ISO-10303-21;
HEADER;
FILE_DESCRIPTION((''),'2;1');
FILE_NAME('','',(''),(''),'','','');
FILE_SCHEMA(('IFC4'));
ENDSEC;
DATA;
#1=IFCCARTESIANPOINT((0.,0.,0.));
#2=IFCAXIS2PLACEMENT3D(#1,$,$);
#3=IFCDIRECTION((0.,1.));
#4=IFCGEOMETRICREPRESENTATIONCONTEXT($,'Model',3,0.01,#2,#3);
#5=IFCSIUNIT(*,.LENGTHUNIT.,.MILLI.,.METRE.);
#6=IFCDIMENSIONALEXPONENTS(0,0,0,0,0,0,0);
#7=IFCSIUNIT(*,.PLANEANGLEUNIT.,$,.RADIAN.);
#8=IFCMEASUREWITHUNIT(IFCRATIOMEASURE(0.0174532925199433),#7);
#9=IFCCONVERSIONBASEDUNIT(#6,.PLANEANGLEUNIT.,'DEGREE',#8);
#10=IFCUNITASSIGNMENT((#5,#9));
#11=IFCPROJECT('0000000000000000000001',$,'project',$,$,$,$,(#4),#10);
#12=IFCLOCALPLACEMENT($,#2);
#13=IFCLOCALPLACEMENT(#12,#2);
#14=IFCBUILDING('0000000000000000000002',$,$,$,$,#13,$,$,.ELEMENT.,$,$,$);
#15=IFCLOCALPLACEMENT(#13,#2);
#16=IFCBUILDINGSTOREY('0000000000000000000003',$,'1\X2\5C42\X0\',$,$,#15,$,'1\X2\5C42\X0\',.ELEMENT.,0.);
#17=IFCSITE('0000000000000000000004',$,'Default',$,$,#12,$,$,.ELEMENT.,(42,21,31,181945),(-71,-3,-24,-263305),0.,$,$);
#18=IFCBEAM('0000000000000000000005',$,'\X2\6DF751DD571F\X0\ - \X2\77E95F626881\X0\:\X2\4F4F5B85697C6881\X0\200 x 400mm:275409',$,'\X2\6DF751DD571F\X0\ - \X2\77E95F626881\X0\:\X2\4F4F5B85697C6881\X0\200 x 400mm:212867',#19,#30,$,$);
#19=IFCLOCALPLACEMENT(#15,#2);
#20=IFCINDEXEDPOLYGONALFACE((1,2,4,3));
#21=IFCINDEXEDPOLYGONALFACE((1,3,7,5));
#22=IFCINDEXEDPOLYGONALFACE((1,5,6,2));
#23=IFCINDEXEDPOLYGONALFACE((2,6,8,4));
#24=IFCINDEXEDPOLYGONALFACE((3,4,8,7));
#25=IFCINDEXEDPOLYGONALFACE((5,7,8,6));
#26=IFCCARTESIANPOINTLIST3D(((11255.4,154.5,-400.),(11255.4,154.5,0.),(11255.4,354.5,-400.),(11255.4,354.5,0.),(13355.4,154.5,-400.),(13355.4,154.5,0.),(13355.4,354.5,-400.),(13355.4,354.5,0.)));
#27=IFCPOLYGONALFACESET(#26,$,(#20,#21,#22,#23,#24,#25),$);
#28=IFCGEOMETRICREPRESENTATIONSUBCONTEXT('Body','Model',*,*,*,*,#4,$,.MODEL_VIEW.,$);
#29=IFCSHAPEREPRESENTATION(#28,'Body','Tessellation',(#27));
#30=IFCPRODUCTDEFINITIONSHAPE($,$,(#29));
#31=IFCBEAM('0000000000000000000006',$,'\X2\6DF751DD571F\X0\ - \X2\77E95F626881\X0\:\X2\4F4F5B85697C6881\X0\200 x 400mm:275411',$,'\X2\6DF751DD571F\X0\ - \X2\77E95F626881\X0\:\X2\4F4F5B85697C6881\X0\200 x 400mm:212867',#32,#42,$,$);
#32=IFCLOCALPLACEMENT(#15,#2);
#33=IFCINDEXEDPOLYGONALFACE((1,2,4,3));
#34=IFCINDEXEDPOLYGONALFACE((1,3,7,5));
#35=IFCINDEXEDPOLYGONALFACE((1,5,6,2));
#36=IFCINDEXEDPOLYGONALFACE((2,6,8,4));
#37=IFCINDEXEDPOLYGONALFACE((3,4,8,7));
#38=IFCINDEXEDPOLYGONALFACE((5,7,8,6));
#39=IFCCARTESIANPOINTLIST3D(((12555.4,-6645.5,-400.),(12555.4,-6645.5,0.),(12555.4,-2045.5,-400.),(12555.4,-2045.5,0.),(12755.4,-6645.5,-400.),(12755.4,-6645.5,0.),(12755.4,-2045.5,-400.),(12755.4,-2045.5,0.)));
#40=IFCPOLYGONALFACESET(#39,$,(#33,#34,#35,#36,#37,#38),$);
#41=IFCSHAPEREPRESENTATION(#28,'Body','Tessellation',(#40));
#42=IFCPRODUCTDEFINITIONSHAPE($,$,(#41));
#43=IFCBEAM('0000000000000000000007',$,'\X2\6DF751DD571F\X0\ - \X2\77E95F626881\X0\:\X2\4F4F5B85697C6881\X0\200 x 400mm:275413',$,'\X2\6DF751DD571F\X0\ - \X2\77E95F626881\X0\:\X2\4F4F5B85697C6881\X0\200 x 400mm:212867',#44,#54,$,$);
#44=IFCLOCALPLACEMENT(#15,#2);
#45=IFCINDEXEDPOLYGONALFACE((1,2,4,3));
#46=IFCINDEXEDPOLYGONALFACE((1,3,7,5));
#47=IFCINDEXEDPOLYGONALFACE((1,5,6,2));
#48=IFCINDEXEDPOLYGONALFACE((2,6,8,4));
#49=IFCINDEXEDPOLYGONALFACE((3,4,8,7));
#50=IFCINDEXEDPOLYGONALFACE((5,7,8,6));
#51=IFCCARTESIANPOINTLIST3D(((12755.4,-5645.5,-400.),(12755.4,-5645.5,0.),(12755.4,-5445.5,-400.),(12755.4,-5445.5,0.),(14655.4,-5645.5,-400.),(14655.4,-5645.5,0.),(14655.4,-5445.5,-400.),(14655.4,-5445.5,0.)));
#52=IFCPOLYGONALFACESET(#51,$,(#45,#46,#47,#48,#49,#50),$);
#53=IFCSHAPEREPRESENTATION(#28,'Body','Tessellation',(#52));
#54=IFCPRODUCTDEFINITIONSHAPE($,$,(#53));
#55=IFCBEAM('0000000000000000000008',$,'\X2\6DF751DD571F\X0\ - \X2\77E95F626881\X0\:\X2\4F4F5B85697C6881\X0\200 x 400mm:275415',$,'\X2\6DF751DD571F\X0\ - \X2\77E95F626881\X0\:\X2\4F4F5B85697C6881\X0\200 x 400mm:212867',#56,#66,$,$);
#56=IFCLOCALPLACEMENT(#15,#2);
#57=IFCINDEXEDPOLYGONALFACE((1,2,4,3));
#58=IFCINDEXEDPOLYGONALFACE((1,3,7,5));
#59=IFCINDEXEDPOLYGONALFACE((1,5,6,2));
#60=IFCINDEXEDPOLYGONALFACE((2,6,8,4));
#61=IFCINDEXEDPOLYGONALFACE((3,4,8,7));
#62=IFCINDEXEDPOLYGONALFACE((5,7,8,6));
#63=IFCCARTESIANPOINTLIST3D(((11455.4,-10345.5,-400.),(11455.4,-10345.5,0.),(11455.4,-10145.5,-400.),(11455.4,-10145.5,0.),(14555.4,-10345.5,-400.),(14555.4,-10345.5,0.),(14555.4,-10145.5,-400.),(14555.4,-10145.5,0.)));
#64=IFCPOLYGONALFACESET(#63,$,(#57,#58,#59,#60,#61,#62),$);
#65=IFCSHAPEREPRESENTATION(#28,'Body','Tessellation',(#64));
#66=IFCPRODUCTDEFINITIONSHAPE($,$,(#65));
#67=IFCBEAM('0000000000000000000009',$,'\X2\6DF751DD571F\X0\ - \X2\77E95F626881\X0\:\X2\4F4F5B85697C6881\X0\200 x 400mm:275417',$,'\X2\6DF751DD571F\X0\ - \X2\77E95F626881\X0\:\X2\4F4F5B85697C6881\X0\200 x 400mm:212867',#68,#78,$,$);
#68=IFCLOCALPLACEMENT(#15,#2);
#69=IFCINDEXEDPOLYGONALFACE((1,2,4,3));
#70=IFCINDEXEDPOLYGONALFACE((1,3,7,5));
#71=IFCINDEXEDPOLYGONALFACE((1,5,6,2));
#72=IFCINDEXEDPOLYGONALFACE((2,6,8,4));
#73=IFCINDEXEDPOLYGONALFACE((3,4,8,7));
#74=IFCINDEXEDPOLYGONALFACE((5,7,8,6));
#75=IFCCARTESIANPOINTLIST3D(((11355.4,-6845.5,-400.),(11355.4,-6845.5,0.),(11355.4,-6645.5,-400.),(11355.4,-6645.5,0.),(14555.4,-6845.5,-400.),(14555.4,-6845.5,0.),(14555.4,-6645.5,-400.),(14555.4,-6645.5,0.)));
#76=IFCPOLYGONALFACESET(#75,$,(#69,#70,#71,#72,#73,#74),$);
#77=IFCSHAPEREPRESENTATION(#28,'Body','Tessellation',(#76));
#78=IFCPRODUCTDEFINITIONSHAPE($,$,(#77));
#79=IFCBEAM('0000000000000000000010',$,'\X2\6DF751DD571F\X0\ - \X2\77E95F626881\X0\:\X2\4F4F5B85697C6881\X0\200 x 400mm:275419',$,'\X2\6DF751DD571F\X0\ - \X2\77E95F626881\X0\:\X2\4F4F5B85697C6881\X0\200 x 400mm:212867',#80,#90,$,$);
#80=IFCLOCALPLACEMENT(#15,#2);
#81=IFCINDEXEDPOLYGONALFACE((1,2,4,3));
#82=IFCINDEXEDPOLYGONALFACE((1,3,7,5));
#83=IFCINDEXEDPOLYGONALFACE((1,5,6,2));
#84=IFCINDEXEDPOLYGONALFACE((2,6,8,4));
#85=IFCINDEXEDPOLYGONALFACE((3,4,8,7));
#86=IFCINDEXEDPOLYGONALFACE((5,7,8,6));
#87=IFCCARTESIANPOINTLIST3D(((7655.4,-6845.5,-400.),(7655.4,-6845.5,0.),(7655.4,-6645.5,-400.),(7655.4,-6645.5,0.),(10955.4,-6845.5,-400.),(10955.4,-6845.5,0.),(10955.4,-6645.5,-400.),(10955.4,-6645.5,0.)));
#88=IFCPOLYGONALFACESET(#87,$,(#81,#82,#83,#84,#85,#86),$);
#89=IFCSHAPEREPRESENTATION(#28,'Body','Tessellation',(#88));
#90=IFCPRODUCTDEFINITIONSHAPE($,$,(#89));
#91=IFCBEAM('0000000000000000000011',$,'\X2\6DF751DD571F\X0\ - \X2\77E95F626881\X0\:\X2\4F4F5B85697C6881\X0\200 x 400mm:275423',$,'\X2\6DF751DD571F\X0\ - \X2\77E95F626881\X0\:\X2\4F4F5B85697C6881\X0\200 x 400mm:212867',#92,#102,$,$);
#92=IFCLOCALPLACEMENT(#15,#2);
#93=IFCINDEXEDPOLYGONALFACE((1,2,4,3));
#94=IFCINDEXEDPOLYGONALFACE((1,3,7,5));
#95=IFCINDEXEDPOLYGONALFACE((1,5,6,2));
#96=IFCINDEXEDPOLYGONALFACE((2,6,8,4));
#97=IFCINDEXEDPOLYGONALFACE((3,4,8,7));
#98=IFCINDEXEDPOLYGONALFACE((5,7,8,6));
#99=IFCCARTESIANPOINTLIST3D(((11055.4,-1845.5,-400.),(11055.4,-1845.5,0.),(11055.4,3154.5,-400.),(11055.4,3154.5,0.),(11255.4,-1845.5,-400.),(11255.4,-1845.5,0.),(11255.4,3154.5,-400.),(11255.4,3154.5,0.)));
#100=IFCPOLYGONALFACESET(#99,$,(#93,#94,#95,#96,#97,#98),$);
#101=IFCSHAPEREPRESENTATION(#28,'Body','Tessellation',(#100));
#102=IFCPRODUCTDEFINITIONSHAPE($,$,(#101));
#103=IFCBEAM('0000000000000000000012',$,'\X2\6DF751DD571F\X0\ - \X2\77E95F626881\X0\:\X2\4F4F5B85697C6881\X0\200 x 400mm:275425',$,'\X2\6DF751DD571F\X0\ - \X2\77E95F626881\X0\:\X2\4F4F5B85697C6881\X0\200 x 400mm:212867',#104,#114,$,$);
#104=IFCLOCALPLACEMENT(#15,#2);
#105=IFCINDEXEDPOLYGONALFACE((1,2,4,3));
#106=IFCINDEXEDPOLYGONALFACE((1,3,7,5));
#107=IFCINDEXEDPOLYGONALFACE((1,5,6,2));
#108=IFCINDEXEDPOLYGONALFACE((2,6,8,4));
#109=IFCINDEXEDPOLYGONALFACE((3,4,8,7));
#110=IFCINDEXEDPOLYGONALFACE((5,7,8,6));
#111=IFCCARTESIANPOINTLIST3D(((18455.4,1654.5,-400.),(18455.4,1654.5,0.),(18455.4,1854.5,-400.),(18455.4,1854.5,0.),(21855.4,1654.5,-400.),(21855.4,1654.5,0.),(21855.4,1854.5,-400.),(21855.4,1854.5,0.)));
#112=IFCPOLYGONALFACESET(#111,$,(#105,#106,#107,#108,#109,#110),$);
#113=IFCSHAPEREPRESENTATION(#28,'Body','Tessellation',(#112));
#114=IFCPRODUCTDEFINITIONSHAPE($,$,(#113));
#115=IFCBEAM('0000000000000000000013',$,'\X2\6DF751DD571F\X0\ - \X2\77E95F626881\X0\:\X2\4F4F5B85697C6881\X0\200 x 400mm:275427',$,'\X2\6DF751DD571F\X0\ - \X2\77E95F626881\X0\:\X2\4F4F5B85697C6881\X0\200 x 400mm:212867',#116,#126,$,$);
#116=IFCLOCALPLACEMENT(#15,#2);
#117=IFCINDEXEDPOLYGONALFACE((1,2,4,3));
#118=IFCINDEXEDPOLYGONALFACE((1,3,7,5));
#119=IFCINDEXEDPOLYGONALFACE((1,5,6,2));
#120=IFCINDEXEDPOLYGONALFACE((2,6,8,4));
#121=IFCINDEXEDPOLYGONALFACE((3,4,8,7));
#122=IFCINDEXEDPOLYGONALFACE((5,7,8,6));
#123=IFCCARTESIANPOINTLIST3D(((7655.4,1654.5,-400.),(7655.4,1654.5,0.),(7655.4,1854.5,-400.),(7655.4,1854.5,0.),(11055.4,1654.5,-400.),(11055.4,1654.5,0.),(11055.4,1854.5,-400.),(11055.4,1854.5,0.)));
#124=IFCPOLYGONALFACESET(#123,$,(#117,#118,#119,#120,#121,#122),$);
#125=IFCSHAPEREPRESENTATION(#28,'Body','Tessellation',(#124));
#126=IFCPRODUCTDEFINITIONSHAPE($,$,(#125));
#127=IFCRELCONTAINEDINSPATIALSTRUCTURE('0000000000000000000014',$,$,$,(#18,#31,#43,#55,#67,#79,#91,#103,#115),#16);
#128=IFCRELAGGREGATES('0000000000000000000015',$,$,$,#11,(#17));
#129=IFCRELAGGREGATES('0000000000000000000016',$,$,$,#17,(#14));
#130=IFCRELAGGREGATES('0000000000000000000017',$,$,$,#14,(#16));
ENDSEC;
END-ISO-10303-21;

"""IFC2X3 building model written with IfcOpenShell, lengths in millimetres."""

from ifc_helpers import new_model, entity, si_unit, converted_unit, direction, frame, frame_2d, origin, place, context, subcontext, project, spatial, rectangle, extrude, element, save


model = new_model("IFC2X3")

# Units and contexts
model_context = context("Model", 3, precision=0.01, world=origin(), true_north=direction((0.0, 1.0)))
body_context = subcontext(model_context, "Body", "Model", "MODEL_VIEW")
ifc_project = project(units=[si_unit("LENGTHUNIT", "METRE", prefix="MILLI"), converted_unit("PLANEANGLEUNIT", "DEGREE", entity("IfcRatioMeasure", 0.0174532925199433), si_unit("PLANEANGLEUNIT", "RADIAN"), dimensions=[0, 0, 0, 0, 0, 0, 0])], contexts=[model_context])

# Site, building, storey
site_placement = place(None, origin())
site = spatial("IfcSite", under=ifc_project, at=site_placement, Name="Default", CompositionType="ELEMENT", RefLatitude=(42, 21, 31, 181945), RefLongitude=(-71, -3, -24, -263305), RefElevation=0.0)
building_placement = place(site_placement, origin())
building = spatial("IfcBuilding", under=site, at=building_placement, CompositionType="ELEMENT")
storey_placement = place(building_placement, origin())
storey = spatial("IfcBuildingStorey", under=building, at=storey_placement, Name="1层", LongName="1层", CompositionType="ELEMENT", Elevation=0.0)

# Beams
beam_1_placement = place(storey_placement, frame((11155.4, 254.5, 0.0)))
element("IfcBeam", 1, at=beam_1_placement, inside=storey, Name="混凝土 - 矩形梁:住宅楼梁200 x 400mm:275409", ObjectType="混凝土 - 矩形梁:住宅楼梁200 x 400mm:212867", context=body_context, shape_type="SweptSolid", body=[
    extrude(rectangle(XDim=400.0, YDim=200.0, at=frame_2d((0.0, 0.0), x_axis=(1.0, 0.0))), frame((100.0, 0.0, -200.0), z_axis=(1.0, 0.0, 0.0), x_axis=(0.0, 0.0, -1.0)), (0.0, 0.0, 1.0), 2100.0),
])
beam_2_placement = place(storey_placement, frame((12655.4, -1945.5, 0.0), z_axis=(0.0, 0.0, 1.0), x_axis=(0.0, -1.0, 0.0)))
element("IfcBeam", 2, at=beam_2_placement, inside=storey, Name="混凝土 - 矩形梁:住宅楼梁200 x 400mm:275411", ObjectType="混凝土 - 矩形梁:住宅楼梁200 x 400mm:212867", context=body_context, shape_type="SweptSolid", body=[
    extrude(rectangle(XDim=400.0, YDim=200.0, at=frame_2d((0.0, 0.0), x_axis=(1.0, 0.0))), frame((100.0, 0.0, -200.0), z_axis=(1.0, 0.0, 0.0), x_axis=(0.0, 0.0, -1.0)), (0.0, 0.0, 1.0), 4600.0),
])
beam_3_placement = place(storey_placement, frame((12655.4, -5545.5, 0.0)))
element("IfcBeam", 3, at=beam_3_placement, inside=storey, Name="混凝土 - 矩形梁:住宅楼梁200 x 400mm:275413", ObjectType="混凝土 - 矩形梁:住宅楼梁200 x 400mm:212867", context=body_context, shape_type="SweptSolid", body=[
    extrude(rectangle(XDim=400.0, YDim=200.0, at=frame_2d((0.0, 0.0), x_axis=(1.0, 0.0))), frame((100.0, 0.0, -200.0), z_axis=(1.0, 0.0, 0.0), x_axis=(0.0, 0.0, -1.0)), (0.0, 0.0, 1.0), 1900.0),
])
beam_4_placement = place(storey_placement, frame((11455.4, -10245.5, 0.0)))
element("IfcBeam", 4, at=beam_4_placement, inside=storey, Name="混凝土 - 矩形梁:住宅楼梁200 x 400mm:275415", ObjectType="混凝土 - 矩形梁:住宅楼梁200 x 400mm:212867", context=body_context, shape_type="SweptSolid", body=[
    extrude(rectangle(XDim=400.0, YDim=200.0, at=frame_2d((0.0, 0.0), x_axis=(1.0, 0.0))), frame((0.0, 0.0, -200.0), z_axis=(1.0, 0.0, 0.0), x_axis=(0.0, 0.0, -1.0)), (0.0, 0.0, 1.0), 3100.0),
])
beam_5_placement = place(storey_placement, frame((11155.4, -6745.5, 0.0)))
element("IfcBeam", 5, at=beam_5_placement, inside=storey, Name="混凝土 - 矩形梁:住宅楼梁200 x 400mm:275417", ObjectType="混凝土 - 矩形梁:住宅楼梁200 x 400mm:212867", context=body_context, shape_type="SweptSolid", body=[
    extrude(rectangle(XDim=400.0, YDim=200.0, at=frame_2d((0.0, 0.0), x_axis=(1.0, 0.0))), frame((200.0, 0.0, -200.0), z_axis=(1.0, 0.0, 0.0), x_axis=(0.0, 0.0, -1.0)), (0.0, 0.0, 1.0), 3200.0),
])
beam_6_placement = place(storey_placement, frame((11155.4, -6745.5, 0.0), z_axis=(0.0, 0.0, 1.0), x_axis=(-1.0, 0.0, 0.0)))
element("IfcBeam", 6, at=beam_6_placement, inside=storey, Name="混凝土 - 矩形梁:住宅楼梁200 x 400mm:275419", ObjectType="混凝土 - 矩形梁:住宅楼梁200 x 400mm:212867", context=body_context, shape_type="SweptSolid", body=[
    extrude(rectangle(XDim=400.0, YDim=200.0, at=frame_2d((0.0, 0.0), x_axis=(1.0, 0.0))), frame((200.0, 0.0, -200.0), z_axis=(1.0, 0.0, 0.0), x_axis=(0.0, 0.0, -1.0)), (0.0, 0.0, 1.0), 3300.0),
])
beam_7_placement = place(storey_placement, frame((11155.4, 3254.5, 0.0), z_axis=(0.0, 0.0, 1.0), x_axis=(0.0, -1.0, 0.0)))
element("IfcBeam", 7, at=beam_7_placement, inside=storey, Name="混凝土 - 矩形梁:住宅楼梁200 x 400mm:275423", ObjectType="混凝土 - 矩形梁:住宅楼梁200 x 400mm:212867", context=body_context, shape_type="SweptSolid", body=[
    extrude(rectangle(XDim=400.0, YDim=200.0, at=frame_2d((0.0, 0.0), x_axis=(1.0, 0.0))), frame((100.0, 0.0, -200.0), z_axis=(1.0, 0.0, 0.0), x_axis=(0.0, 0.0, -1.0)), (0.0, 0.0, 1.0), 5000.0),
])
beam_8_placement = place(storey_placement, frame((21955.4, 1754.5, 0.0), z_axis=(0.0, 0.0, 1.0), x_axis=(-1.0, 0.0, 0.0)))
element("IfcBeam", 8, at=beam_8_placement, inside=storey, Name="混凝土 - 矩形梁:住宅楼梁200 x 400mm:275425", ObjectType="混凝土 - 矩形梁:住宅楼梁200 x 400mm:212867", context=body_context, shape_type="SweptSolid", body=[
    extrude(rectangle(XDim=400.0, YDim=200.0, at=frame_2d((0.0, 0.0), x_axis=(1.0, 0.0))), frame((100.0, 0.0, -200.0), z_axis=(1.0, 0.0, 0.0), x_axis=(0.0, 0.0, -1.0)), (0.0, 0.0, 1.0), 3400.0),
])
beam_9_placement = place(storey_placement, frame((7555.4, 1754.5, 0.0)))
element("IfcBeam", 9, at=beam_9_placement, inside=storey, Name="混凝土 - 矩形梁:住宅楼梁200 x 400mm:275427", ObjectType="混凝土 - 矩形梁:住宅楼梁200 x 400mm:212867", context=body_context, shape_type="SweptSolid", body=[
    extrude(rectangle(XDim=400.0, YDim=200.0, at=frame_2d((0.0, 0.0), x_axis=(1.0, 0.0))), frame((100.0, 0.0, -200.0), z_axis=(1.0, 0.0, 0.0), x_axis=(0.0, 0.0, -1.0)), (0.0, 0.0, 1.0), 3400.0),
])

save(model, "model.ifc")
